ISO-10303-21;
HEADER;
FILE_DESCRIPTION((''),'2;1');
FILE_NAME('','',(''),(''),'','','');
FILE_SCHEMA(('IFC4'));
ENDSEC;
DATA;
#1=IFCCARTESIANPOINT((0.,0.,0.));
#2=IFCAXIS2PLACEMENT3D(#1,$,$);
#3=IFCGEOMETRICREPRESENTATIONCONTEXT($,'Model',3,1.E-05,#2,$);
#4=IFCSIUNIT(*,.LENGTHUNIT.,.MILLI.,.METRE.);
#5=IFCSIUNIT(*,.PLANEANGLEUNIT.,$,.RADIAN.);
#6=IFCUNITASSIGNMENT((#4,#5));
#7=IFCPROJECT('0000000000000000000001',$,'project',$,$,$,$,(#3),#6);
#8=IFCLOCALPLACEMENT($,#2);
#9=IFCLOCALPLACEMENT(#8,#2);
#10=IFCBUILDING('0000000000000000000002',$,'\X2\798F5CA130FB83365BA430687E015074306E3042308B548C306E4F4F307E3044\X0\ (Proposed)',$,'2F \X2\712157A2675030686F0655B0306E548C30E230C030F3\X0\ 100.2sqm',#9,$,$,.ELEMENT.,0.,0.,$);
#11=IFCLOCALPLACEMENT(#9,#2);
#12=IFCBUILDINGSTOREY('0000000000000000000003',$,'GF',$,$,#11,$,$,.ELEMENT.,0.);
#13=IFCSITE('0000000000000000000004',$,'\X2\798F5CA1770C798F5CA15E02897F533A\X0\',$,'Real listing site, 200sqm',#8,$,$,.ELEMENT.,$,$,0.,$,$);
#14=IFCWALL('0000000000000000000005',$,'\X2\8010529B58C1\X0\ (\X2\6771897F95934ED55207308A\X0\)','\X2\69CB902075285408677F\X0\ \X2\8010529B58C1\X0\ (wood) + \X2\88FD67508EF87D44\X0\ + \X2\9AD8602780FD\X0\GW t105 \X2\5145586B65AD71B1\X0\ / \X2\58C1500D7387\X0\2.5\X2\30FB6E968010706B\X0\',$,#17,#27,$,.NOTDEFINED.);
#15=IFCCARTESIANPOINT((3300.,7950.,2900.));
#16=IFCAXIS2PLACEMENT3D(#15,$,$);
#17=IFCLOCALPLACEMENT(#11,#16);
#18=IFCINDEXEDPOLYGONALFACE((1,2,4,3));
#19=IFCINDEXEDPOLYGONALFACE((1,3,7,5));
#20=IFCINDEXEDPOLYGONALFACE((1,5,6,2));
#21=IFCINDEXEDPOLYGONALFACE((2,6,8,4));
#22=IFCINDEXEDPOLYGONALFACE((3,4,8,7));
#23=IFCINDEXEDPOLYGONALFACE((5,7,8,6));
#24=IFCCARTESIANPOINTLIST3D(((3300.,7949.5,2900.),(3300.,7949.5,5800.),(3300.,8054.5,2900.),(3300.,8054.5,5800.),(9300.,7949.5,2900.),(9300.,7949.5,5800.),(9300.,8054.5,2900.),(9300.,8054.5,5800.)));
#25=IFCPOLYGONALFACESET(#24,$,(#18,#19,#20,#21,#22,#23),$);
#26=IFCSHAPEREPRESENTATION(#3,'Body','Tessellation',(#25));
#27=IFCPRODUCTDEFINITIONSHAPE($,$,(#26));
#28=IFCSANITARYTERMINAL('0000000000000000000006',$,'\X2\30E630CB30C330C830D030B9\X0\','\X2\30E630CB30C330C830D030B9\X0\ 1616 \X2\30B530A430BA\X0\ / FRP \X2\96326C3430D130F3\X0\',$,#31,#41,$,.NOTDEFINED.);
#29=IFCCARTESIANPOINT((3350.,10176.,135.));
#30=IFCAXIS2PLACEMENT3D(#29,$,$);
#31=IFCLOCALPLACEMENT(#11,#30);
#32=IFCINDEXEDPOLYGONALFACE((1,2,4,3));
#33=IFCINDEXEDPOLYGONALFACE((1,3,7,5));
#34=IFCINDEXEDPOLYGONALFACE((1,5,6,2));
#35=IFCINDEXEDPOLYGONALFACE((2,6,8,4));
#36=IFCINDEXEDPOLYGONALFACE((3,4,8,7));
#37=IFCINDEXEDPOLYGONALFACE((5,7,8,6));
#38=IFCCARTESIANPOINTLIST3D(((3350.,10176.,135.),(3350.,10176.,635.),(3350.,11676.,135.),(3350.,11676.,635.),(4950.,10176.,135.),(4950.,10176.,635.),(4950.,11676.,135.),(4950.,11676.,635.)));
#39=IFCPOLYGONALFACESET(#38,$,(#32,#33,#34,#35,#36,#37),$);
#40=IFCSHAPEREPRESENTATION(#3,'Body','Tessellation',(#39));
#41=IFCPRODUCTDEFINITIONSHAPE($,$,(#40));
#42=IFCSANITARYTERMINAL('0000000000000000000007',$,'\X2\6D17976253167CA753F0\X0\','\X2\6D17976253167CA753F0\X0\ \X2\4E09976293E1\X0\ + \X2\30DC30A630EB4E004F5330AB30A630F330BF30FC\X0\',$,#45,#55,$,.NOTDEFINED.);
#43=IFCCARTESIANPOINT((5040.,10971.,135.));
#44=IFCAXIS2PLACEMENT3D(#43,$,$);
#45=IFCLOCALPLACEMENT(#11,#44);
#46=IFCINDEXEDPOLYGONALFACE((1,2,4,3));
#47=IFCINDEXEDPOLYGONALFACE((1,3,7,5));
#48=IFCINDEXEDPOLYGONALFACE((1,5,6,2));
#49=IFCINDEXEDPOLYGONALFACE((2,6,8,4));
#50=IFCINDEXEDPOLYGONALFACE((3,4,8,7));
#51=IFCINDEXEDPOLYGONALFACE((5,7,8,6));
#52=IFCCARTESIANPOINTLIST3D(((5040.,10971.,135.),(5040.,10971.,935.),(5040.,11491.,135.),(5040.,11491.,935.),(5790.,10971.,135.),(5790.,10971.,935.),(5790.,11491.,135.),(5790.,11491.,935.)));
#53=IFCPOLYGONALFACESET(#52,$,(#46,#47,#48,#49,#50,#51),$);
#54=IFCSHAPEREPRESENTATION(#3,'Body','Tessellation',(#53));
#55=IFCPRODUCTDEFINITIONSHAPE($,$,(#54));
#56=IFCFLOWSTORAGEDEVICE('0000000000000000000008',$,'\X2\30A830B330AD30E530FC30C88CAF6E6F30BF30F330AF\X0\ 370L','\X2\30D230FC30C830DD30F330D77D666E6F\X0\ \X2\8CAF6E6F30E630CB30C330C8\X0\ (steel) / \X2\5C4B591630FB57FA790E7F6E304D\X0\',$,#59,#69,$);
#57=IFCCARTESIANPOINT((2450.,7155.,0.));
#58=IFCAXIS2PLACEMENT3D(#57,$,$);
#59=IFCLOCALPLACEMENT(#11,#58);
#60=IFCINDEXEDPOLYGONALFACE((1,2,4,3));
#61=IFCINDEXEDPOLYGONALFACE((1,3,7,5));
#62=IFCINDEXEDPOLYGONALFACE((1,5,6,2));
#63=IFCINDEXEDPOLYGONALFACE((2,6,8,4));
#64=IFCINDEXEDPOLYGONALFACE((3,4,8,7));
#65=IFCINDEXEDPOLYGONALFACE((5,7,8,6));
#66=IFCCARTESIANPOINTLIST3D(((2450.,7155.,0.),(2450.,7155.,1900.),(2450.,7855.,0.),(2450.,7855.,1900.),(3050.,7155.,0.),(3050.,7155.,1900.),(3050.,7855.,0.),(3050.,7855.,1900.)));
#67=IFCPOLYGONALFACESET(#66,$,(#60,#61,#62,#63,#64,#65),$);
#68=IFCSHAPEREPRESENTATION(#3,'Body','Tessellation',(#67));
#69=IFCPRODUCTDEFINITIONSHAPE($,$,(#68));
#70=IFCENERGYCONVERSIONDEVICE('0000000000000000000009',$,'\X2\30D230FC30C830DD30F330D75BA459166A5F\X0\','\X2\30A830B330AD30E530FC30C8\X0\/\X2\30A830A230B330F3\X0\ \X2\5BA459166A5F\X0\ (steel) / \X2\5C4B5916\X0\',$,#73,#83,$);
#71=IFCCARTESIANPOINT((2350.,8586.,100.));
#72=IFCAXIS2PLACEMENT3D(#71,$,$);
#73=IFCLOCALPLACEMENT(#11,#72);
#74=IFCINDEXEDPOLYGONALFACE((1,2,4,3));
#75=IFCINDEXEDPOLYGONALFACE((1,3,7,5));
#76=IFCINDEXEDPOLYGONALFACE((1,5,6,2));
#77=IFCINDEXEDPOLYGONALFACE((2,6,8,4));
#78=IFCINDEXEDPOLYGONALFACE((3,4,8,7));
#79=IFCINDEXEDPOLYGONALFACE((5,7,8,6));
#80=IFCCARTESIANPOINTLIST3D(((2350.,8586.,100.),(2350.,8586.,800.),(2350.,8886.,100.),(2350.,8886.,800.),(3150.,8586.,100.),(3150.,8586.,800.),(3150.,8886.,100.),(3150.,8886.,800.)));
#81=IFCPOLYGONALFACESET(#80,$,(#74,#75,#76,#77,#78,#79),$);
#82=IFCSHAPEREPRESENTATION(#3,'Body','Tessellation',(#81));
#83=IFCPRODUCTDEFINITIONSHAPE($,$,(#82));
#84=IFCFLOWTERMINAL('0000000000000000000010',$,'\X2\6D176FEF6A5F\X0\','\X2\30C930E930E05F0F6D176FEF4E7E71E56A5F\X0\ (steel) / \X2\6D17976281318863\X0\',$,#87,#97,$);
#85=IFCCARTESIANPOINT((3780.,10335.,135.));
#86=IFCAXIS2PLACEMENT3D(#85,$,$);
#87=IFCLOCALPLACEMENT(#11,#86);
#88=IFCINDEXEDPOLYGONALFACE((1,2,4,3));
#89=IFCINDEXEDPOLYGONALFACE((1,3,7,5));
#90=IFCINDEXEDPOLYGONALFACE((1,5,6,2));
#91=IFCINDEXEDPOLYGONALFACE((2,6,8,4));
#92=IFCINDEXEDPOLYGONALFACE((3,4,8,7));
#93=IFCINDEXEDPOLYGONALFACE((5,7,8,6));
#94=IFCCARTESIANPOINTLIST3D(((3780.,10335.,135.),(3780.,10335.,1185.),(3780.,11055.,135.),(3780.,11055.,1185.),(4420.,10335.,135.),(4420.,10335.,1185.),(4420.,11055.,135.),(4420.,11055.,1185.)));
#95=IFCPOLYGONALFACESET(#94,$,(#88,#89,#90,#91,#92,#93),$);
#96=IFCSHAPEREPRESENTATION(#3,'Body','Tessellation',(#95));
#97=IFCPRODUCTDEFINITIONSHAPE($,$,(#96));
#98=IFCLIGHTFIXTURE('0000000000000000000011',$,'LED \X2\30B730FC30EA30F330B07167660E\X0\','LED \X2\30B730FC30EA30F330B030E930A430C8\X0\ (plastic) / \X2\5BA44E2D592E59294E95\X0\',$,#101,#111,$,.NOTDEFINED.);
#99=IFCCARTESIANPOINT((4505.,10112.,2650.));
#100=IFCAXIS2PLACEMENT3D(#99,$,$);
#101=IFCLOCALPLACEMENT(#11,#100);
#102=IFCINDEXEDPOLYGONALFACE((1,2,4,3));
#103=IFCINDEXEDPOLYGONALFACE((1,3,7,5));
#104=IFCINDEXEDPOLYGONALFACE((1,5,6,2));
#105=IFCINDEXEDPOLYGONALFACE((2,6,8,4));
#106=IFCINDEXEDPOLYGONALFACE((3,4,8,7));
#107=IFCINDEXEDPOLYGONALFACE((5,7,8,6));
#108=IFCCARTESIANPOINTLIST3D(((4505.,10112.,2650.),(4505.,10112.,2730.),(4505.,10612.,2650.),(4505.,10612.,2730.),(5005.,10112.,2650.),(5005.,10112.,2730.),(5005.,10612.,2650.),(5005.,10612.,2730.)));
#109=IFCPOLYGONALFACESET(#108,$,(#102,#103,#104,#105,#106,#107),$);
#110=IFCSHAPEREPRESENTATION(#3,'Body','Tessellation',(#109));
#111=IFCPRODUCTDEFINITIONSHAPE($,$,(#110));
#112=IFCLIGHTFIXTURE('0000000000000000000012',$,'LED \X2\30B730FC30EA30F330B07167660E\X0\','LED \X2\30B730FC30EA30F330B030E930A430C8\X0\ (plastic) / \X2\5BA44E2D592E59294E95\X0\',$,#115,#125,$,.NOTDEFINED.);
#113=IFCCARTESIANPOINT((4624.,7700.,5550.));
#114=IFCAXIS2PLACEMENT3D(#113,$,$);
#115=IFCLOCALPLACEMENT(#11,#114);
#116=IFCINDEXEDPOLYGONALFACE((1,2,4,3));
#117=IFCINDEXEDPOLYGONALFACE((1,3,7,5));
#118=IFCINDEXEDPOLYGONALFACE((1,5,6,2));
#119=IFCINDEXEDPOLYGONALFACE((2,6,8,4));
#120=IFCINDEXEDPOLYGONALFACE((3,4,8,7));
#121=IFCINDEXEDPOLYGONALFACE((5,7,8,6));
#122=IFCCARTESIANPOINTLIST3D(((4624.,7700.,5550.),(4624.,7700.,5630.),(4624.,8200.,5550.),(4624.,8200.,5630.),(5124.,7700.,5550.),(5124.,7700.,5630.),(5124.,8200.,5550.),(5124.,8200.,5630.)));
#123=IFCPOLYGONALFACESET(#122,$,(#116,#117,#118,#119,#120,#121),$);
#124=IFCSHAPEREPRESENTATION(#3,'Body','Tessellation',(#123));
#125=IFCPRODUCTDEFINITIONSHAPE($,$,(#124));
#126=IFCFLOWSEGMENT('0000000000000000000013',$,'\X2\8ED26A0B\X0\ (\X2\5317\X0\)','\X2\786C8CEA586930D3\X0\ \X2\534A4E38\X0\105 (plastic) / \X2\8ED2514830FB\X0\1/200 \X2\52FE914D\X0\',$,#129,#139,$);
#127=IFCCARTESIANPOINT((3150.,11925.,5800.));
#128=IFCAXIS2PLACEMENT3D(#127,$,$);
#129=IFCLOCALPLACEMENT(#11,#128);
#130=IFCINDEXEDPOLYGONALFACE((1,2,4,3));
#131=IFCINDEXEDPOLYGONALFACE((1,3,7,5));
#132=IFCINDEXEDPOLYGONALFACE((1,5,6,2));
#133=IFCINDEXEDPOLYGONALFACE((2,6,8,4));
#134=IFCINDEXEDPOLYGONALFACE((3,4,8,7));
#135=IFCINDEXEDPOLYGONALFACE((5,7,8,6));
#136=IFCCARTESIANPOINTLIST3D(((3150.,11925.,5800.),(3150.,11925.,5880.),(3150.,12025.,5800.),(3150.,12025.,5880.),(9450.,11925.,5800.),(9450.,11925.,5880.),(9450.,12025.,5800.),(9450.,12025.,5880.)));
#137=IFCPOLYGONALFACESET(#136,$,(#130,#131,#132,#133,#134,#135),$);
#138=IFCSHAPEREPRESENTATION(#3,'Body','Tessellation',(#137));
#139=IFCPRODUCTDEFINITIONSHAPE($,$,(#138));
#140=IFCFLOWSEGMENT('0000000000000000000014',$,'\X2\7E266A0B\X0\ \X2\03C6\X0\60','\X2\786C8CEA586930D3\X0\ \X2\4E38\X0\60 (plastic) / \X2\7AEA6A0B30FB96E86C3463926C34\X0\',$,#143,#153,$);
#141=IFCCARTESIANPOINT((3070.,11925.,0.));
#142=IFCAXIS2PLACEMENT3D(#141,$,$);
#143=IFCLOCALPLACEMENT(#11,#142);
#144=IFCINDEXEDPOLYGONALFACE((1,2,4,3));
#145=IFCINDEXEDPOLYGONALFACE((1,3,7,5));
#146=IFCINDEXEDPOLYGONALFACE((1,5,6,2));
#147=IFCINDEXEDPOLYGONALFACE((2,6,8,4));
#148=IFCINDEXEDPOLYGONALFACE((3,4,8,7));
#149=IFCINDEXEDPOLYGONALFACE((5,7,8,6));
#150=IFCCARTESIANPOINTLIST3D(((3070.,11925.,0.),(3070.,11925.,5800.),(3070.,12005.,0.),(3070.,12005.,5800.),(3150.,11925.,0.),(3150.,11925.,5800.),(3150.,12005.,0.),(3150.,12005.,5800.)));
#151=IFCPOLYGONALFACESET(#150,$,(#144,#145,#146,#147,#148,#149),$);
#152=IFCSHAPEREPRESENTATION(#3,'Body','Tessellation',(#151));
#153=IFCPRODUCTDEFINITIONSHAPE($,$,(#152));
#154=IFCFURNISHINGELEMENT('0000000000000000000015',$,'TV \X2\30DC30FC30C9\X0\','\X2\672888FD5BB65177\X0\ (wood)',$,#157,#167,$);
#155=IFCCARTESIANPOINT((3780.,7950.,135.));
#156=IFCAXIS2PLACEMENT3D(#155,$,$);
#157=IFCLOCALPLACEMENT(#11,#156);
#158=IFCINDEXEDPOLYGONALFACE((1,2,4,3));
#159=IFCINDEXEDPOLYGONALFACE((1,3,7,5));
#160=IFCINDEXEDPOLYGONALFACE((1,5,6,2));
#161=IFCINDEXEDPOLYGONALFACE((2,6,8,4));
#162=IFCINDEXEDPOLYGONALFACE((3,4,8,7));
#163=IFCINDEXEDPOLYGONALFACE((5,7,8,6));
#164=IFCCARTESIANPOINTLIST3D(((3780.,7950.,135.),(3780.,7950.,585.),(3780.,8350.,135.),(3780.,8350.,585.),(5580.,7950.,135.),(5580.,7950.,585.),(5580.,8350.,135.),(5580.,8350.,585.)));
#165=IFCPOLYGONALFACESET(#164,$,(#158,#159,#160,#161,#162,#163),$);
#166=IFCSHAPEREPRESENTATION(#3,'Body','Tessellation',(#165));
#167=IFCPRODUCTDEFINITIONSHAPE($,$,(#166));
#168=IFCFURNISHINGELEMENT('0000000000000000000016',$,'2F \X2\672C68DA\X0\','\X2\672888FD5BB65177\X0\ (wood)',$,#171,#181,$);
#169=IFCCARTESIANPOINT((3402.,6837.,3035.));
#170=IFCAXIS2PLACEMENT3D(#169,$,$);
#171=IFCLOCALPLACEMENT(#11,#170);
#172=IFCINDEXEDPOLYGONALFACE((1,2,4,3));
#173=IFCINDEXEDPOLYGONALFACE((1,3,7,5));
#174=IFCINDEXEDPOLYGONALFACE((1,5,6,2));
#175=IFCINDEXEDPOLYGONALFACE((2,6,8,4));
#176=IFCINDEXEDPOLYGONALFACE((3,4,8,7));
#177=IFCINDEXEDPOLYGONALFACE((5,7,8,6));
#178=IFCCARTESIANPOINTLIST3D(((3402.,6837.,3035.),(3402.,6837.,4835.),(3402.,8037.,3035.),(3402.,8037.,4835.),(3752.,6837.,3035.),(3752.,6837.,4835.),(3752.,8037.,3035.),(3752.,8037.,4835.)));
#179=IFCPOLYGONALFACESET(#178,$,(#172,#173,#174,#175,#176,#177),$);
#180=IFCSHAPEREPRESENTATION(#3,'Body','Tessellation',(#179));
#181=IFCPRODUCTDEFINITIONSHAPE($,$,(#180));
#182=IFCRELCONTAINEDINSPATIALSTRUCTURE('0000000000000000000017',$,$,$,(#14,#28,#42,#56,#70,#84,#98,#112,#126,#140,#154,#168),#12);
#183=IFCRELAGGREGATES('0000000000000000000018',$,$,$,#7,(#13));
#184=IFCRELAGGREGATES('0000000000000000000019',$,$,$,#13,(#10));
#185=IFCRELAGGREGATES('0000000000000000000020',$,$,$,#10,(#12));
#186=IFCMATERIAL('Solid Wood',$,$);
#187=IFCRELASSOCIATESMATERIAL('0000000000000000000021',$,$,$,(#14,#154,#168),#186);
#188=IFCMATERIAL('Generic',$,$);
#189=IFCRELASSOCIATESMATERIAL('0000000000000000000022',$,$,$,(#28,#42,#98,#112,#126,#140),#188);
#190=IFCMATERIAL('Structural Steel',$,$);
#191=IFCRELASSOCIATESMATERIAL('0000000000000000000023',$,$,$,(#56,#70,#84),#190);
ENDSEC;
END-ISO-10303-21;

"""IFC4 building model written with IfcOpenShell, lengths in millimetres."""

from ifc_helpers import new_model, si_unit, frame, frame_2d, origin, place, context, project, spatial, rectangle, extrude, material, element, save


model = new_model("IFC4")

# Units and contexts
model_context = context("Model", 3, precision=1e-05, world=origin())
ifc_project = project(units=[si_unit("LENGTHUNIT", "METRE", prefix="MILLI"), si_unit("PLANEANGLEUNIT", "RADIAN")], contexts=[model_context])

# Site, building, storey
site_placement = place(None, origin())
site = spatial("IfcSite", under=ifc_project, at=site_placement, Name="福岡県福岡市西区", ObjectType="Real listing site, 200sqm", CompositionType="ELEMENT", RefElevation=0.0)
building_placement = place(site_placement, origin())
building = spatial("IfcBuilding", under=site, at=building_placement, Name="福岡・茶室と縁側のある和の住まい (Proposed)", ObjectType="2F 無垢材と漆喰の和モダン 100.2sqm", CompositionType="ELEMENT", ElevationOfRefHeight=0.0, ElevationOfTerrain=0.0)
storey_placement = place(building_placement, origin())
storey = spatial("IfcBuildingStorey", under=building, at=storey_placement, Name="GF", CompositionType="ELEMENT", Elevation=0.0)

# Shared definitions
ifc_material_1 = material(Name="Solid Wood")

# Wall
wall_1_placement = place(storey_placement, frame((3300.0, 7950.0, 2900.0)))
element("IfcWall", 1, at=wall_1_placement, inside=storey, material=ifc_material_1, Name="耐力壁 (東西間仕切り)", Description="構造用合板 耐力壁 (wood) + 製材軸組 + 高性能GW t105 充填断熱 / 壁倍率2.5・準耐火", PredefinedType="NOTDEFINED", context=model_context, shape_type="SweptSolid", body=[
    extrude(rectangle(XDim=6000.0, YDim=105.0, at=frame_2d((3000.0, 52.0))), frame((3300.0, 7950.0, 2900.0)), (0.0, 0.0, 1.0), 2900.0),
])

# Sanitary terminals
ifc_material_2 = material(Name="Generic")
sanitary_terminal_1_placement = place(storey_placement, frame((3350.0, 10176.0, 135.0)))
element("IfcSanitaryTerminal", 2, at=sanitary_terminal_1_placement, inside=storey, material=ifc_material_2, Name="ユニットバス", Description="ユニットバス 1616 サイズ / FRP 防水パン", PredefinedType="NOTDEFINED", context=model_context, shape_type="SweptSolid", body=[
    extrude(rectangle(XDim=1600.0, YDim=1500.0, at=frame_2d((800.0, 750.0))), frame((3350.0, 10176.0, 135.0)), (0.0, 0.0, 1.0), 500.0),
])
sanitary_terminal_2_placement = place(storey_placement, frame((5040.0, 10971.0, 135.0)))
element("IfcSanitaryTerminal", 3, at=sanitary_terminal_2_placement, inside=storey, material=ifc_material_2, Name="洗面化粧台", Description="洗面化粧台 三面鏡 + ボウル一体カウンター", PredefinedType="NOTDEFINED", context=model_context, shape_type="SweptSolid", body=[
    extrude(rectangle(XDim=750.0, YDim=520.0, at=frame_2d((375.0, 260.0))), frame((5040.0, 10971.0, 135.0)), (0.0, 0.0, 1.0), 800.0),
])

# Flow storage device
ifc_material_3 = material(Name="Structural Steel")
flow_storage_device_placement = place(storey_placement, frame((2450.0, 7155.0, 0.0)))
element("IfcFlowStorageDevice", 4, at=flow_storage_device_placement, inside=storey, material=ifc_material_3, Name="エコキュート貯湯タンク 370L", Description="ヒートポンプ給湯 貯湯ユニット (steel) / 屋外・基礎置き", context=model_context, shape_type="SweptSolid", body=[
    extrude(rectangle(XDim=600.0, YDim=700.0, at=frame_2d((300.0, 350.0))), frame((2450.0, 7155.0, 0.0)), (0.0, 0.0, 1.0), 1900.0),
])

# Energy conversion device
energy_conversion_device_placement = place(storey_placement, frame((2350.0, 8586.0, 100.0)))
element("IfcEnergyConversionDevice", 5, at=energy_conversion_device_placement, inside=storey, material=ifc_material_3, Name="ヒートポンプ室外機", Description="エコキュート/エアコン 室外機 (steel) / 屋外", context=model_context, shape_type="SweptSolid", body=[
    extrude(rectangle(XDim=800.0, YDim=300.0, at=frame_2d((400.0, 150.0))), frame((2350.0, 8586.0, 100.0)), (0.0, 0.0, 1.0), 700.0),
])

# Flow terminal
flow_terminal_placement = place(storey_placement, frame((3780.0, 10335.0, 135.0)))
element("IfcFlowTerminal", 6, at=flow_terminal_placement, inside=storey, material=ifc_material_3, Name="洗濯機", Description="ドラム式洗濯乾燥機 (steel) / 洗面脱衣", context=model_context, shape_type="SweptSolid", body=[
    extrude(rectangle(XDim=640.0, YDim=720.0, at=frame_2d((320.0, 360.0))), frame((3780.0, 10335.0, 135.0)), (0.0, 0.0, 1.0), 1050.0),
])

# Light fixtures
light_fixture_1_placement = place(storey_placement, frame((4505.0, 10112.0, 2650.0)))
element("IfcLightFixture", 7, at=light_fixture_1_placement, inside=storey, material=ifc_material_2, Name="LED シーリング照明", Description="LED シーリングライト (plastic) / 室中央天井", PredefinedType="NOTDEFINED", context=model_context, shape_type="SweptSolid", body=[
    extrude(rectangle(XDim=500.0, YDim=500.0, at=frame_2d((250.0, 250.0))), frame((4505.0, 10112.0, 2650.0)), (0.0, 0.0, 1.0), 80.0),
])
light_fixture_2_placement = place(storey_placement, frame((4624.0, 7700.0, 5550.0)))
element("IfcLightFixture", 8, at=light_fixture_2_placement, inside=storey, material=ifc_material_2, Name="LED シーリング照明", Description="LED シーリングライト (plastic) / 室中央天井", PredefinedType="NOTDEFINED", context=model_context, shape_type="SweptSolid", body=[
    extrude(rectangle(XDim=500.0, YDim=500.0, at=frame_2d((250.0, 250.0))), frame((4624.0, 7700.0, 5550.0)), (0.0, 0.0, 1.0), 80.0),
])

# Flow segments
flow_segment_1_placement = place(storey_placement, frame((3150.0, 11925.0, 5800.0)))
element("IfcFlowSegment", 9, at=flow_segment_1_placement, inside=storey, material=ifc_material_2, Name="軒樋 (北)", Description="硬質塩ビ 半丸105 (plastic) / 軒先・1/200 勾配", context=model_context, shape_type="SweptSolid", body=[
    extrude(rectangle(XDim=6300.0, YDim=100.0, at=frame_2d((3150.0, 50.0))), frame((3150.0, 11925.0, 5800.0)), (0.0, 0.0, 1.0), 80.0),
])
flow_segment_2_placement = place(storey_placement, frame((3070.0, 11925.0, 0.0)))
element("IfcFlowSegment", 10, at=flow_segment_2_placement, inside=storey, material=ifc_material_2, Name="縦樋 φ60", Description="硬質塩ビ 丸60 (plastic) / 竪樋・雨水排水", context=model_context, shape_type="SweptSolid", body=[
    extrude(rectangle(XDim=80.0, YDim=80.0, at=frame_2d((40.0, 40.0))), frame((3070.0, 11925.0, 0.0)), (0.0, 0.0, 1.0), 5800.0),
])

# Furnishing elements
furnishing_1_placement = place(storey_placement, frame((3780.0, 7950.0, 135.0)))
element("IfcFurnishingElement", 11, at=furnishing_1_placement, inside=storey, material=ifc_material_1, Name="TV ボード", Description="木製家具 (wood)", context=model_context, shape_type="SweptSolid", body=[
    extrude(rectangle(XDim=1800.0, YDim=400.0, at=frame_2d((900.0, 200.0))), frame((3780.0, 7950.0, 135.0)), (0.0, 0.0, 1.0), 450.0),
])
furnishing_2_placement = place(storey_placement, frame((3402.0, 6837.0, 3035.0)))
element("IfcFurnishingElement", 12, at=furnishing_2_placement, inside=storey, material=ifc_material_1, Name="2F 本棚", Description="木製家具 (wood)", context=model_context, shape_type="SweptSolid", body=[
    extrude(rectangle(XDim=350.0, YDim=1200.0, at=frame_2d((175.0, 600.0))), frame((3402.0, 6837.0, 3035.0)), (0.0, 0.0, 1.0), 1800.0),
])

save(model, "model.ifc")
